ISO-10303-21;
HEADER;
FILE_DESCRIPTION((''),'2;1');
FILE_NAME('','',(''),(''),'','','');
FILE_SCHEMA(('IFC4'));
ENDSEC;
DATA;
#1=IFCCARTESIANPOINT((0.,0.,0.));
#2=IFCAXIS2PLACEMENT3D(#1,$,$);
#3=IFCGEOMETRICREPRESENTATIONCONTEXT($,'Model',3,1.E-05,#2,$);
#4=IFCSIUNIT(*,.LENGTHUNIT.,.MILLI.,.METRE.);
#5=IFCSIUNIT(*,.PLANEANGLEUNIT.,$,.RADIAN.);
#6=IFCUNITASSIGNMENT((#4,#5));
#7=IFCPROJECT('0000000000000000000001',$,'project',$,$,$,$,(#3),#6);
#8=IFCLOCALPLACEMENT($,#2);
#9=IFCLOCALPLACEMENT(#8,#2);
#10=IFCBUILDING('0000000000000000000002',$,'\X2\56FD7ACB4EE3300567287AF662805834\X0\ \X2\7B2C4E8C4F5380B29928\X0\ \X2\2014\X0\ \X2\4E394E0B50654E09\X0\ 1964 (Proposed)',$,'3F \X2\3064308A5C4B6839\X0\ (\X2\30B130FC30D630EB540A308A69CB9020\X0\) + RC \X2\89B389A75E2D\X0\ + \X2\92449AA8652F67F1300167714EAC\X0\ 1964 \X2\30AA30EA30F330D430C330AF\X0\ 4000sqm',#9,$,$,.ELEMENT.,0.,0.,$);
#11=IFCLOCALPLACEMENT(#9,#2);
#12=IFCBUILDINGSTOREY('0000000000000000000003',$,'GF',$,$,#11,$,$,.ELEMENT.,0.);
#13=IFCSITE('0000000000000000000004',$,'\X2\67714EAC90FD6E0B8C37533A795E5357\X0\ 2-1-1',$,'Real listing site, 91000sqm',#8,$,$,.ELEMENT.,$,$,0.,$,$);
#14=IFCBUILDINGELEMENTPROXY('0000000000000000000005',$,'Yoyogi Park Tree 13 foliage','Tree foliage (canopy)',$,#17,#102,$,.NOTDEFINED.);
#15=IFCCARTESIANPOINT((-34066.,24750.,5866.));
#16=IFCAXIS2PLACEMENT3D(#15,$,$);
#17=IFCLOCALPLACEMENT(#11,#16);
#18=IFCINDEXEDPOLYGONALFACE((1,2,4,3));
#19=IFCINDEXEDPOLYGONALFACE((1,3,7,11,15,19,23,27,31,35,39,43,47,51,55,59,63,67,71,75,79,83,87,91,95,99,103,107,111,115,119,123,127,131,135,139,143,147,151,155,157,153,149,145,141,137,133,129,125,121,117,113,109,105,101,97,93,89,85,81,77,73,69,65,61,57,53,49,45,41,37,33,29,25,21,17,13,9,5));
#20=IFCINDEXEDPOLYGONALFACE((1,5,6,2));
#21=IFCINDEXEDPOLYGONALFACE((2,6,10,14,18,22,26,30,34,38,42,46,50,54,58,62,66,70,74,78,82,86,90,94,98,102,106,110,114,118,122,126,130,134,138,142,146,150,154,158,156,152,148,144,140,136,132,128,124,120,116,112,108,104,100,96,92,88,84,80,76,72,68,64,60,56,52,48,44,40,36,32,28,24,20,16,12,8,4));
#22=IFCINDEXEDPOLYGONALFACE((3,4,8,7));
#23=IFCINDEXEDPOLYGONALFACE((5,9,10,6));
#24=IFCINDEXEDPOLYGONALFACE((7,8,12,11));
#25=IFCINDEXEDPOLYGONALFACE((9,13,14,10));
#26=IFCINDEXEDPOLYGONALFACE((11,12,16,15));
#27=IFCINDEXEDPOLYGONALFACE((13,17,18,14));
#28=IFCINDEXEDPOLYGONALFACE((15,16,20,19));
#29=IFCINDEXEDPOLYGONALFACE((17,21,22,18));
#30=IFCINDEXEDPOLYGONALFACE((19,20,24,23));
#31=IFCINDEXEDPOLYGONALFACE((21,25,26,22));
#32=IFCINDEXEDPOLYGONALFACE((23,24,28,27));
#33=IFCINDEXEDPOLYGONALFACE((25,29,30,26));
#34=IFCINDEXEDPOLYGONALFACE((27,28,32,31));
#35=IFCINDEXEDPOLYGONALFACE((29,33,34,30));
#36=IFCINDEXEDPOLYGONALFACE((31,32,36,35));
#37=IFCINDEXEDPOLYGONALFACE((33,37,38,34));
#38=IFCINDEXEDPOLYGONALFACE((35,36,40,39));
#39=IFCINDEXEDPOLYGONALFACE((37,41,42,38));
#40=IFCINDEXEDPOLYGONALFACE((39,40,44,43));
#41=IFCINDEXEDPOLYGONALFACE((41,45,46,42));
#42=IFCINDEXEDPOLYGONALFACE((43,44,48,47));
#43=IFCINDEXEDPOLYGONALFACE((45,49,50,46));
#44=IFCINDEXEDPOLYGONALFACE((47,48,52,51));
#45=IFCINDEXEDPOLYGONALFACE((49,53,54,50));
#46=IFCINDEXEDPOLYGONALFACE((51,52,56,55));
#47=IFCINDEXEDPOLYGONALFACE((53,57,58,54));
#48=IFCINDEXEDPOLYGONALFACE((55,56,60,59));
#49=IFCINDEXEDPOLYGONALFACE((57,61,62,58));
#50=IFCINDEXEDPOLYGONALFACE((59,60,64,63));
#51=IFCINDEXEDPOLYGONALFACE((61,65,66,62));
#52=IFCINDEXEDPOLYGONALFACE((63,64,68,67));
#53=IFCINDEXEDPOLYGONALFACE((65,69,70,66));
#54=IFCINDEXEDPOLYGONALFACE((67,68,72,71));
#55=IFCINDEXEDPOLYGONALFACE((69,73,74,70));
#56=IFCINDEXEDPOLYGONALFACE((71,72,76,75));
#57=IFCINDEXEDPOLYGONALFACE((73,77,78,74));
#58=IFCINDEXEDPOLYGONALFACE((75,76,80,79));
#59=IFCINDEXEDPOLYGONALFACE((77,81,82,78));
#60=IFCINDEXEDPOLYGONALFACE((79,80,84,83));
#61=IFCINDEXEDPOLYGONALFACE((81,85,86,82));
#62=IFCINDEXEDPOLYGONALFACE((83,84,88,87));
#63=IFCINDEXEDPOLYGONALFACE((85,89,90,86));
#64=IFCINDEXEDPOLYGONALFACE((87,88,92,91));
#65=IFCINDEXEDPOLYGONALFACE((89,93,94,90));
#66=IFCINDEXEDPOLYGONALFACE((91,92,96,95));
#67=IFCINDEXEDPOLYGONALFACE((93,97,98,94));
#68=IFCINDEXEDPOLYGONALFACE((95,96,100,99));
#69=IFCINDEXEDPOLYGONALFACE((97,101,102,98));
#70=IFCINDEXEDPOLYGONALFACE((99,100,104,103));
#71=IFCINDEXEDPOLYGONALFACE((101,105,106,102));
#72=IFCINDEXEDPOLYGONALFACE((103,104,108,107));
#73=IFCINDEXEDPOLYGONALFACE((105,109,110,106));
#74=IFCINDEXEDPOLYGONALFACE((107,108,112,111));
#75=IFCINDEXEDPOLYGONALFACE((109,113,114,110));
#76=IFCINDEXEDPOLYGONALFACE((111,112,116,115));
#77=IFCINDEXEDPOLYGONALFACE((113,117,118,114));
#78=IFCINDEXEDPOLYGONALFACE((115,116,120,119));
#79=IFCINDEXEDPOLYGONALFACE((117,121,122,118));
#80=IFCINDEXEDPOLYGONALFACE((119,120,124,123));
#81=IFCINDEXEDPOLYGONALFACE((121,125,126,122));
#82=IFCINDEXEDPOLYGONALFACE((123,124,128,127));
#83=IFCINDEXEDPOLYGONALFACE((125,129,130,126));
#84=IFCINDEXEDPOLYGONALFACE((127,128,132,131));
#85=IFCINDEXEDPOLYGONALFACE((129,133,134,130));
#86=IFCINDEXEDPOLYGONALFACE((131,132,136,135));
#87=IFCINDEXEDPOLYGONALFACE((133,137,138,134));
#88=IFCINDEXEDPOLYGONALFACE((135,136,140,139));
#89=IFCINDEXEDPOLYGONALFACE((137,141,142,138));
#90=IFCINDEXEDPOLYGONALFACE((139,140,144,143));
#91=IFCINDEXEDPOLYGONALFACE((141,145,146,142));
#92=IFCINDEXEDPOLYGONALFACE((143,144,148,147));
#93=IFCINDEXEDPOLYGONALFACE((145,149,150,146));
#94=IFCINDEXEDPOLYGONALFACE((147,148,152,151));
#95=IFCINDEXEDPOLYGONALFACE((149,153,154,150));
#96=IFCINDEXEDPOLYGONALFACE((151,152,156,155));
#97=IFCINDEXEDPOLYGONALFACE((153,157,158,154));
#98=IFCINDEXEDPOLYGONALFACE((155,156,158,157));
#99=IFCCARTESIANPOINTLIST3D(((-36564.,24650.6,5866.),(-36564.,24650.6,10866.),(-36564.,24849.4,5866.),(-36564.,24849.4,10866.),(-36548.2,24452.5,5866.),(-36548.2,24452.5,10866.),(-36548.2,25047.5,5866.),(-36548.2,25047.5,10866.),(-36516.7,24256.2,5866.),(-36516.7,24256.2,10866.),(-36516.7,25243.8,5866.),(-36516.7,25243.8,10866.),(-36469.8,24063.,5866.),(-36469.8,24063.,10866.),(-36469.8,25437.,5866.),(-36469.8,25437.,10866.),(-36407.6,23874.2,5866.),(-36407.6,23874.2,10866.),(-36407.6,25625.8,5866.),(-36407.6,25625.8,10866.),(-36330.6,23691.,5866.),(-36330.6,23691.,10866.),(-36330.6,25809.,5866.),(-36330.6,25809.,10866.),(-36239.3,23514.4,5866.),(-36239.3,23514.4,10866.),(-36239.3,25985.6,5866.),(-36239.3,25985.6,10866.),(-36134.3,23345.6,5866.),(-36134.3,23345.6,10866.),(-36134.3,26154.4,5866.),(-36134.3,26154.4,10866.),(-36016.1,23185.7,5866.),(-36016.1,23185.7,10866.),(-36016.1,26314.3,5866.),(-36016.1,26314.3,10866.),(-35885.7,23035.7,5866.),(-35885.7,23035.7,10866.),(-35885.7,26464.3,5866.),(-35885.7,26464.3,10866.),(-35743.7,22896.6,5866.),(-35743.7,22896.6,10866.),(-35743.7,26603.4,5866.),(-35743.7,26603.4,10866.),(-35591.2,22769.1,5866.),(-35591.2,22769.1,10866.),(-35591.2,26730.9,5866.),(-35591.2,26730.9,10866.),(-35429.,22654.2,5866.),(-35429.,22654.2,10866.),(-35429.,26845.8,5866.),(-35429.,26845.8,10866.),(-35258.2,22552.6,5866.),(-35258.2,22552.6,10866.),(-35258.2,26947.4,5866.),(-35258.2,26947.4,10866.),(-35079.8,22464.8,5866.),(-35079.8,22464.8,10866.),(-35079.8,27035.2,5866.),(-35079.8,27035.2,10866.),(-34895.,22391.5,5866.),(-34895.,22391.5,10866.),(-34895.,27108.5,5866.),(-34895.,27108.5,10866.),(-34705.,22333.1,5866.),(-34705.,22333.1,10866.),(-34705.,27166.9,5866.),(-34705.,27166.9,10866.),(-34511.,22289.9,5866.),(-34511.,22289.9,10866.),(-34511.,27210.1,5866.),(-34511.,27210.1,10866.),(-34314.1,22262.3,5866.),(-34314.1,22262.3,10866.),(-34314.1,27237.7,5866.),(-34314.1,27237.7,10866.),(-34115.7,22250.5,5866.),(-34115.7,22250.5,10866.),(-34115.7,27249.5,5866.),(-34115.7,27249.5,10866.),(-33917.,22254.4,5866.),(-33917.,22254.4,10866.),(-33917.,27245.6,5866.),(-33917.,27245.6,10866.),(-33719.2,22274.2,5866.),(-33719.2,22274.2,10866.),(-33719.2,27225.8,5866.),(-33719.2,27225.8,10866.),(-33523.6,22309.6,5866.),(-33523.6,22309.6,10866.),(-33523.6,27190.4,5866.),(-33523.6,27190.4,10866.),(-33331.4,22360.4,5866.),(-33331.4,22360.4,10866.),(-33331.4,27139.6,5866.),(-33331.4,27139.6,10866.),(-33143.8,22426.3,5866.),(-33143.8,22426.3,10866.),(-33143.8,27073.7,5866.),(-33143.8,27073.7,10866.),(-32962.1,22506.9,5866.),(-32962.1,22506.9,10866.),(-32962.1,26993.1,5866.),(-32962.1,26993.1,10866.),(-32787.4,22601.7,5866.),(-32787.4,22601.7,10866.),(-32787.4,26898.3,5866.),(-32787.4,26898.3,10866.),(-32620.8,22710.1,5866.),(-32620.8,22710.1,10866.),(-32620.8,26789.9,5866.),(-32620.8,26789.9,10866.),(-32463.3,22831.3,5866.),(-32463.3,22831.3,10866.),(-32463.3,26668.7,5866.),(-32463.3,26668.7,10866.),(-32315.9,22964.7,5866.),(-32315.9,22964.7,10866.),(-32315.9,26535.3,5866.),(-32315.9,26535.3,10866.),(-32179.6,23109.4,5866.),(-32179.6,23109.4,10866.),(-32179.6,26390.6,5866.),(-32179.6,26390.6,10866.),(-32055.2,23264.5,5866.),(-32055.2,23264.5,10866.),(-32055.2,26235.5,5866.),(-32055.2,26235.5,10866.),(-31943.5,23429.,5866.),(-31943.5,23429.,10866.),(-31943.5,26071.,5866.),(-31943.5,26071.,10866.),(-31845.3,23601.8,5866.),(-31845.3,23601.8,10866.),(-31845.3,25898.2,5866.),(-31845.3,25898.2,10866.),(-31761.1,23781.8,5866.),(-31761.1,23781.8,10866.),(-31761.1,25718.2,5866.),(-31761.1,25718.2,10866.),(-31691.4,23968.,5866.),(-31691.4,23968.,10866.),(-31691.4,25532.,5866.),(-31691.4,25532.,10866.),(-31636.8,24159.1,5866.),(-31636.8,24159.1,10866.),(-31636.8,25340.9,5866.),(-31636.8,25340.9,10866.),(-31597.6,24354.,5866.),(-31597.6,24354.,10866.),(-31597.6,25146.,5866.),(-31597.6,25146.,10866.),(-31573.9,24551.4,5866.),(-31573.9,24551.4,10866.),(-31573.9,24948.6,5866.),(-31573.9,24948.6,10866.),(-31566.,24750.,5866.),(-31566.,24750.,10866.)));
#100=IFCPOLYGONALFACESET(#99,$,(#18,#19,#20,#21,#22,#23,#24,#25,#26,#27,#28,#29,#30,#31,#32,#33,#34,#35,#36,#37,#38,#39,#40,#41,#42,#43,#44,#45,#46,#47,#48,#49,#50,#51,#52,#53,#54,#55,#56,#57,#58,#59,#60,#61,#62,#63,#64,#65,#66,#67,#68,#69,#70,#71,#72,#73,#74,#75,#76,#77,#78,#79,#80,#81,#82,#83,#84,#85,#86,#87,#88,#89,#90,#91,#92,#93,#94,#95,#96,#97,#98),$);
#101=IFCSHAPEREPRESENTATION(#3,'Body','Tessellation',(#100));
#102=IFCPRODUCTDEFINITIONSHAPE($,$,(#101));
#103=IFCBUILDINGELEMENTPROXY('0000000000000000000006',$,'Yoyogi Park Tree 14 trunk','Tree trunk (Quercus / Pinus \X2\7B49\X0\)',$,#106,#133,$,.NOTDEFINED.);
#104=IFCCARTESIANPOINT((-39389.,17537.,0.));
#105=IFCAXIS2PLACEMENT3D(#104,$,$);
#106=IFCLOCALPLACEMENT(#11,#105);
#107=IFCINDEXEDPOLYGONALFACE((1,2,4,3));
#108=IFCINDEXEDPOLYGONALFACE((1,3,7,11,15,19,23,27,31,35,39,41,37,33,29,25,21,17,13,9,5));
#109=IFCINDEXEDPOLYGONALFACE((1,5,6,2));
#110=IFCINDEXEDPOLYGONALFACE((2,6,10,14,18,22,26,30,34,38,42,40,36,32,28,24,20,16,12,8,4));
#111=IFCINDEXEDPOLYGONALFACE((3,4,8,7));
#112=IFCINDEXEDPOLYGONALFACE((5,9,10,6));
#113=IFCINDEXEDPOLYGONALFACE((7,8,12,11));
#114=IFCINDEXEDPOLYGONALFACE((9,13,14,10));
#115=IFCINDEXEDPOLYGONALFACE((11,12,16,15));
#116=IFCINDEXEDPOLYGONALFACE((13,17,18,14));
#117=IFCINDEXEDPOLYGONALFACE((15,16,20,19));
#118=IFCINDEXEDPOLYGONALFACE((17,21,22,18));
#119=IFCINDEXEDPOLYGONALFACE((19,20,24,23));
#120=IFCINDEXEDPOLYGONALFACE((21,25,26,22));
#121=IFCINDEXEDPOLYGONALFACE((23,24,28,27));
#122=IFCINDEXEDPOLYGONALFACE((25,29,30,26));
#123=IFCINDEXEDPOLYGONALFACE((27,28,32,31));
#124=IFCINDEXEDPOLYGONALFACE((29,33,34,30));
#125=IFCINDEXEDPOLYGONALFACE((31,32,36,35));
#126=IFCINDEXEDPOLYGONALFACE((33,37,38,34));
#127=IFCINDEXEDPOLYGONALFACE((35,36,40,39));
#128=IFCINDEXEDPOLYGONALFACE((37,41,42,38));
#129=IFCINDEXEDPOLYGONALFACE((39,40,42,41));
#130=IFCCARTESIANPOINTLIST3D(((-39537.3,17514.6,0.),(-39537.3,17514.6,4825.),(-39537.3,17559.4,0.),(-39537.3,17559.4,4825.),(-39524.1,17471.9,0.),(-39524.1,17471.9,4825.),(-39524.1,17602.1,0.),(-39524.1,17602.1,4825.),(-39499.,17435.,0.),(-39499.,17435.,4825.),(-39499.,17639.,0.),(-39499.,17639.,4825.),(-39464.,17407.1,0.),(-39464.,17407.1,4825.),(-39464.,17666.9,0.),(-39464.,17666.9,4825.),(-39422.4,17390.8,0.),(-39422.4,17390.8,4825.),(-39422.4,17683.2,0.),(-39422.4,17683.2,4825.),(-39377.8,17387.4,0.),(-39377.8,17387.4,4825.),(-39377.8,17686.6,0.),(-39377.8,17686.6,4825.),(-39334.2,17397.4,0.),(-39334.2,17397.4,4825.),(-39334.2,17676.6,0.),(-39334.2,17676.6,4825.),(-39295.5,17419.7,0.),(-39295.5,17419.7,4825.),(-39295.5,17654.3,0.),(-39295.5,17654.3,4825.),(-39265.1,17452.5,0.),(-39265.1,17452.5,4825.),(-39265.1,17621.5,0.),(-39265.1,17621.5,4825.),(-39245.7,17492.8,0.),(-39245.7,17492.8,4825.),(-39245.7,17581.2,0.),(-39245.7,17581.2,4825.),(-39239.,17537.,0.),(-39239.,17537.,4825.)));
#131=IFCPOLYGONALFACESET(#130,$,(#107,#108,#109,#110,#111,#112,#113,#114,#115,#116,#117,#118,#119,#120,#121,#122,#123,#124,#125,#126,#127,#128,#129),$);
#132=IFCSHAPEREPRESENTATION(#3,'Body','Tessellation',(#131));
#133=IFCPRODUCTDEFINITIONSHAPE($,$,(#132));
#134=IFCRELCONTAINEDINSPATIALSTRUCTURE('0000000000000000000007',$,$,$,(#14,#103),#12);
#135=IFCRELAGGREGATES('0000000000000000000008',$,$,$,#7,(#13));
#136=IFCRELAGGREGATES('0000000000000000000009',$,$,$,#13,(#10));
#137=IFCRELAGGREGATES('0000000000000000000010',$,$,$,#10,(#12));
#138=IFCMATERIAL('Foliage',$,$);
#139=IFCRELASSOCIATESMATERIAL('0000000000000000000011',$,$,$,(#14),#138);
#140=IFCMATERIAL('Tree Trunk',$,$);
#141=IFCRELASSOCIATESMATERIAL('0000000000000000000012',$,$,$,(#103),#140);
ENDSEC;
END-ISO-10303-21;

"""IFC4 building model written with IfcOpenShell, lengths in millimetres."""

from ifc_helpers import new_model, si_unit, frame, origin, origin_2d, place, context, project, spatial, circle, extrude, material, element, save


model = new_model("IFC4")

# Units and contexts
model_context = context("Model", 3, precision=1e-05, world=origin())
ifc_project = project(units=[si_unit("LENGTHUNIT", "METRE", prefix="MILLI"), si_unit("PLANEANGLEUNIT", "RADIAN")], contexts=[model_context])

# Site, building, storey
site_placement = place(None, origin())
site = spatial("IfcSite", under=ifc_project, at=site_placement, Name="東京都渋谷区神南 2-1-1", ObjectType="Real listing site, 91000sqm", CompositionType="ELEMENT", RefElevation=0.0)
building_placement = place(site_placement, origin())
building = spatial("IfcBuilding", under=site, at=building_placement, Name="国立代々木競技場 第二体育館 — 丹下健三 1964 (Proposed)", ObjectType="3F つり屋根 (ケーブル吊り構造) + RC 観覧席 + 鉄骨支柱、東京 1964 オリンピック 4000sqm", CompositionType="ELEMENT", ElevationOfRefHeight=0.0, ElevationOfTerrain=0.0)
storey_placement = place(building_placement, origin())
storey = spatial("IfcBuildingStorey", under=building, at=storey_placement, Name="GF", CompositionType="ELEMENT", Elevation=0.0)

# Building element proxies
ifc_material_1 = material(Name="Tree Trunk")
ifc_material_2 = material(Name="Foliage")
proxy_1_placement = place(storey_placement, frame((-34066.0, 24750.0, 5866.0)))
element("IfcBuildingElementProxy", 1, at=proxy_1_placement, inside=storey, material=ifc_material_2, Name="Yoyogi Park Tree 13 foliage", Description="Tree foliage (canopy)", PredefinedType="NOTDEFINED", context=model_context, shape_type="SweptSolid", body=[
    extrude(circle(Radius=2500.0, at=origin_2d()), frame((-34066.0, 24750.0, 5866.0)), (0.0, 0.0, 1.0), 5000.0),
])
proxy_2_placement = place(storey_placement, frame((-39389.0, 17537.0, 0.0)))
element("IfcBuildingElementProxy", 2, at=proxy_2_placement, inside=storey, material=ifc_material_1, Name="Yoyogi Park Tree 14 trunk", Description="Tree trunk (Quercus / Pinus 等)", PredefinedType="NOTDEFINED", context=model_context, shape_type="SweptSolid", body=[
    extrude(circle(Radius=150.0, at=origin_2d()), frame((-39389.0, 17537.0, 0.0)), (0.0, 0.0, 1.0), 4825.0),
])

save(model, "model.ifc")
